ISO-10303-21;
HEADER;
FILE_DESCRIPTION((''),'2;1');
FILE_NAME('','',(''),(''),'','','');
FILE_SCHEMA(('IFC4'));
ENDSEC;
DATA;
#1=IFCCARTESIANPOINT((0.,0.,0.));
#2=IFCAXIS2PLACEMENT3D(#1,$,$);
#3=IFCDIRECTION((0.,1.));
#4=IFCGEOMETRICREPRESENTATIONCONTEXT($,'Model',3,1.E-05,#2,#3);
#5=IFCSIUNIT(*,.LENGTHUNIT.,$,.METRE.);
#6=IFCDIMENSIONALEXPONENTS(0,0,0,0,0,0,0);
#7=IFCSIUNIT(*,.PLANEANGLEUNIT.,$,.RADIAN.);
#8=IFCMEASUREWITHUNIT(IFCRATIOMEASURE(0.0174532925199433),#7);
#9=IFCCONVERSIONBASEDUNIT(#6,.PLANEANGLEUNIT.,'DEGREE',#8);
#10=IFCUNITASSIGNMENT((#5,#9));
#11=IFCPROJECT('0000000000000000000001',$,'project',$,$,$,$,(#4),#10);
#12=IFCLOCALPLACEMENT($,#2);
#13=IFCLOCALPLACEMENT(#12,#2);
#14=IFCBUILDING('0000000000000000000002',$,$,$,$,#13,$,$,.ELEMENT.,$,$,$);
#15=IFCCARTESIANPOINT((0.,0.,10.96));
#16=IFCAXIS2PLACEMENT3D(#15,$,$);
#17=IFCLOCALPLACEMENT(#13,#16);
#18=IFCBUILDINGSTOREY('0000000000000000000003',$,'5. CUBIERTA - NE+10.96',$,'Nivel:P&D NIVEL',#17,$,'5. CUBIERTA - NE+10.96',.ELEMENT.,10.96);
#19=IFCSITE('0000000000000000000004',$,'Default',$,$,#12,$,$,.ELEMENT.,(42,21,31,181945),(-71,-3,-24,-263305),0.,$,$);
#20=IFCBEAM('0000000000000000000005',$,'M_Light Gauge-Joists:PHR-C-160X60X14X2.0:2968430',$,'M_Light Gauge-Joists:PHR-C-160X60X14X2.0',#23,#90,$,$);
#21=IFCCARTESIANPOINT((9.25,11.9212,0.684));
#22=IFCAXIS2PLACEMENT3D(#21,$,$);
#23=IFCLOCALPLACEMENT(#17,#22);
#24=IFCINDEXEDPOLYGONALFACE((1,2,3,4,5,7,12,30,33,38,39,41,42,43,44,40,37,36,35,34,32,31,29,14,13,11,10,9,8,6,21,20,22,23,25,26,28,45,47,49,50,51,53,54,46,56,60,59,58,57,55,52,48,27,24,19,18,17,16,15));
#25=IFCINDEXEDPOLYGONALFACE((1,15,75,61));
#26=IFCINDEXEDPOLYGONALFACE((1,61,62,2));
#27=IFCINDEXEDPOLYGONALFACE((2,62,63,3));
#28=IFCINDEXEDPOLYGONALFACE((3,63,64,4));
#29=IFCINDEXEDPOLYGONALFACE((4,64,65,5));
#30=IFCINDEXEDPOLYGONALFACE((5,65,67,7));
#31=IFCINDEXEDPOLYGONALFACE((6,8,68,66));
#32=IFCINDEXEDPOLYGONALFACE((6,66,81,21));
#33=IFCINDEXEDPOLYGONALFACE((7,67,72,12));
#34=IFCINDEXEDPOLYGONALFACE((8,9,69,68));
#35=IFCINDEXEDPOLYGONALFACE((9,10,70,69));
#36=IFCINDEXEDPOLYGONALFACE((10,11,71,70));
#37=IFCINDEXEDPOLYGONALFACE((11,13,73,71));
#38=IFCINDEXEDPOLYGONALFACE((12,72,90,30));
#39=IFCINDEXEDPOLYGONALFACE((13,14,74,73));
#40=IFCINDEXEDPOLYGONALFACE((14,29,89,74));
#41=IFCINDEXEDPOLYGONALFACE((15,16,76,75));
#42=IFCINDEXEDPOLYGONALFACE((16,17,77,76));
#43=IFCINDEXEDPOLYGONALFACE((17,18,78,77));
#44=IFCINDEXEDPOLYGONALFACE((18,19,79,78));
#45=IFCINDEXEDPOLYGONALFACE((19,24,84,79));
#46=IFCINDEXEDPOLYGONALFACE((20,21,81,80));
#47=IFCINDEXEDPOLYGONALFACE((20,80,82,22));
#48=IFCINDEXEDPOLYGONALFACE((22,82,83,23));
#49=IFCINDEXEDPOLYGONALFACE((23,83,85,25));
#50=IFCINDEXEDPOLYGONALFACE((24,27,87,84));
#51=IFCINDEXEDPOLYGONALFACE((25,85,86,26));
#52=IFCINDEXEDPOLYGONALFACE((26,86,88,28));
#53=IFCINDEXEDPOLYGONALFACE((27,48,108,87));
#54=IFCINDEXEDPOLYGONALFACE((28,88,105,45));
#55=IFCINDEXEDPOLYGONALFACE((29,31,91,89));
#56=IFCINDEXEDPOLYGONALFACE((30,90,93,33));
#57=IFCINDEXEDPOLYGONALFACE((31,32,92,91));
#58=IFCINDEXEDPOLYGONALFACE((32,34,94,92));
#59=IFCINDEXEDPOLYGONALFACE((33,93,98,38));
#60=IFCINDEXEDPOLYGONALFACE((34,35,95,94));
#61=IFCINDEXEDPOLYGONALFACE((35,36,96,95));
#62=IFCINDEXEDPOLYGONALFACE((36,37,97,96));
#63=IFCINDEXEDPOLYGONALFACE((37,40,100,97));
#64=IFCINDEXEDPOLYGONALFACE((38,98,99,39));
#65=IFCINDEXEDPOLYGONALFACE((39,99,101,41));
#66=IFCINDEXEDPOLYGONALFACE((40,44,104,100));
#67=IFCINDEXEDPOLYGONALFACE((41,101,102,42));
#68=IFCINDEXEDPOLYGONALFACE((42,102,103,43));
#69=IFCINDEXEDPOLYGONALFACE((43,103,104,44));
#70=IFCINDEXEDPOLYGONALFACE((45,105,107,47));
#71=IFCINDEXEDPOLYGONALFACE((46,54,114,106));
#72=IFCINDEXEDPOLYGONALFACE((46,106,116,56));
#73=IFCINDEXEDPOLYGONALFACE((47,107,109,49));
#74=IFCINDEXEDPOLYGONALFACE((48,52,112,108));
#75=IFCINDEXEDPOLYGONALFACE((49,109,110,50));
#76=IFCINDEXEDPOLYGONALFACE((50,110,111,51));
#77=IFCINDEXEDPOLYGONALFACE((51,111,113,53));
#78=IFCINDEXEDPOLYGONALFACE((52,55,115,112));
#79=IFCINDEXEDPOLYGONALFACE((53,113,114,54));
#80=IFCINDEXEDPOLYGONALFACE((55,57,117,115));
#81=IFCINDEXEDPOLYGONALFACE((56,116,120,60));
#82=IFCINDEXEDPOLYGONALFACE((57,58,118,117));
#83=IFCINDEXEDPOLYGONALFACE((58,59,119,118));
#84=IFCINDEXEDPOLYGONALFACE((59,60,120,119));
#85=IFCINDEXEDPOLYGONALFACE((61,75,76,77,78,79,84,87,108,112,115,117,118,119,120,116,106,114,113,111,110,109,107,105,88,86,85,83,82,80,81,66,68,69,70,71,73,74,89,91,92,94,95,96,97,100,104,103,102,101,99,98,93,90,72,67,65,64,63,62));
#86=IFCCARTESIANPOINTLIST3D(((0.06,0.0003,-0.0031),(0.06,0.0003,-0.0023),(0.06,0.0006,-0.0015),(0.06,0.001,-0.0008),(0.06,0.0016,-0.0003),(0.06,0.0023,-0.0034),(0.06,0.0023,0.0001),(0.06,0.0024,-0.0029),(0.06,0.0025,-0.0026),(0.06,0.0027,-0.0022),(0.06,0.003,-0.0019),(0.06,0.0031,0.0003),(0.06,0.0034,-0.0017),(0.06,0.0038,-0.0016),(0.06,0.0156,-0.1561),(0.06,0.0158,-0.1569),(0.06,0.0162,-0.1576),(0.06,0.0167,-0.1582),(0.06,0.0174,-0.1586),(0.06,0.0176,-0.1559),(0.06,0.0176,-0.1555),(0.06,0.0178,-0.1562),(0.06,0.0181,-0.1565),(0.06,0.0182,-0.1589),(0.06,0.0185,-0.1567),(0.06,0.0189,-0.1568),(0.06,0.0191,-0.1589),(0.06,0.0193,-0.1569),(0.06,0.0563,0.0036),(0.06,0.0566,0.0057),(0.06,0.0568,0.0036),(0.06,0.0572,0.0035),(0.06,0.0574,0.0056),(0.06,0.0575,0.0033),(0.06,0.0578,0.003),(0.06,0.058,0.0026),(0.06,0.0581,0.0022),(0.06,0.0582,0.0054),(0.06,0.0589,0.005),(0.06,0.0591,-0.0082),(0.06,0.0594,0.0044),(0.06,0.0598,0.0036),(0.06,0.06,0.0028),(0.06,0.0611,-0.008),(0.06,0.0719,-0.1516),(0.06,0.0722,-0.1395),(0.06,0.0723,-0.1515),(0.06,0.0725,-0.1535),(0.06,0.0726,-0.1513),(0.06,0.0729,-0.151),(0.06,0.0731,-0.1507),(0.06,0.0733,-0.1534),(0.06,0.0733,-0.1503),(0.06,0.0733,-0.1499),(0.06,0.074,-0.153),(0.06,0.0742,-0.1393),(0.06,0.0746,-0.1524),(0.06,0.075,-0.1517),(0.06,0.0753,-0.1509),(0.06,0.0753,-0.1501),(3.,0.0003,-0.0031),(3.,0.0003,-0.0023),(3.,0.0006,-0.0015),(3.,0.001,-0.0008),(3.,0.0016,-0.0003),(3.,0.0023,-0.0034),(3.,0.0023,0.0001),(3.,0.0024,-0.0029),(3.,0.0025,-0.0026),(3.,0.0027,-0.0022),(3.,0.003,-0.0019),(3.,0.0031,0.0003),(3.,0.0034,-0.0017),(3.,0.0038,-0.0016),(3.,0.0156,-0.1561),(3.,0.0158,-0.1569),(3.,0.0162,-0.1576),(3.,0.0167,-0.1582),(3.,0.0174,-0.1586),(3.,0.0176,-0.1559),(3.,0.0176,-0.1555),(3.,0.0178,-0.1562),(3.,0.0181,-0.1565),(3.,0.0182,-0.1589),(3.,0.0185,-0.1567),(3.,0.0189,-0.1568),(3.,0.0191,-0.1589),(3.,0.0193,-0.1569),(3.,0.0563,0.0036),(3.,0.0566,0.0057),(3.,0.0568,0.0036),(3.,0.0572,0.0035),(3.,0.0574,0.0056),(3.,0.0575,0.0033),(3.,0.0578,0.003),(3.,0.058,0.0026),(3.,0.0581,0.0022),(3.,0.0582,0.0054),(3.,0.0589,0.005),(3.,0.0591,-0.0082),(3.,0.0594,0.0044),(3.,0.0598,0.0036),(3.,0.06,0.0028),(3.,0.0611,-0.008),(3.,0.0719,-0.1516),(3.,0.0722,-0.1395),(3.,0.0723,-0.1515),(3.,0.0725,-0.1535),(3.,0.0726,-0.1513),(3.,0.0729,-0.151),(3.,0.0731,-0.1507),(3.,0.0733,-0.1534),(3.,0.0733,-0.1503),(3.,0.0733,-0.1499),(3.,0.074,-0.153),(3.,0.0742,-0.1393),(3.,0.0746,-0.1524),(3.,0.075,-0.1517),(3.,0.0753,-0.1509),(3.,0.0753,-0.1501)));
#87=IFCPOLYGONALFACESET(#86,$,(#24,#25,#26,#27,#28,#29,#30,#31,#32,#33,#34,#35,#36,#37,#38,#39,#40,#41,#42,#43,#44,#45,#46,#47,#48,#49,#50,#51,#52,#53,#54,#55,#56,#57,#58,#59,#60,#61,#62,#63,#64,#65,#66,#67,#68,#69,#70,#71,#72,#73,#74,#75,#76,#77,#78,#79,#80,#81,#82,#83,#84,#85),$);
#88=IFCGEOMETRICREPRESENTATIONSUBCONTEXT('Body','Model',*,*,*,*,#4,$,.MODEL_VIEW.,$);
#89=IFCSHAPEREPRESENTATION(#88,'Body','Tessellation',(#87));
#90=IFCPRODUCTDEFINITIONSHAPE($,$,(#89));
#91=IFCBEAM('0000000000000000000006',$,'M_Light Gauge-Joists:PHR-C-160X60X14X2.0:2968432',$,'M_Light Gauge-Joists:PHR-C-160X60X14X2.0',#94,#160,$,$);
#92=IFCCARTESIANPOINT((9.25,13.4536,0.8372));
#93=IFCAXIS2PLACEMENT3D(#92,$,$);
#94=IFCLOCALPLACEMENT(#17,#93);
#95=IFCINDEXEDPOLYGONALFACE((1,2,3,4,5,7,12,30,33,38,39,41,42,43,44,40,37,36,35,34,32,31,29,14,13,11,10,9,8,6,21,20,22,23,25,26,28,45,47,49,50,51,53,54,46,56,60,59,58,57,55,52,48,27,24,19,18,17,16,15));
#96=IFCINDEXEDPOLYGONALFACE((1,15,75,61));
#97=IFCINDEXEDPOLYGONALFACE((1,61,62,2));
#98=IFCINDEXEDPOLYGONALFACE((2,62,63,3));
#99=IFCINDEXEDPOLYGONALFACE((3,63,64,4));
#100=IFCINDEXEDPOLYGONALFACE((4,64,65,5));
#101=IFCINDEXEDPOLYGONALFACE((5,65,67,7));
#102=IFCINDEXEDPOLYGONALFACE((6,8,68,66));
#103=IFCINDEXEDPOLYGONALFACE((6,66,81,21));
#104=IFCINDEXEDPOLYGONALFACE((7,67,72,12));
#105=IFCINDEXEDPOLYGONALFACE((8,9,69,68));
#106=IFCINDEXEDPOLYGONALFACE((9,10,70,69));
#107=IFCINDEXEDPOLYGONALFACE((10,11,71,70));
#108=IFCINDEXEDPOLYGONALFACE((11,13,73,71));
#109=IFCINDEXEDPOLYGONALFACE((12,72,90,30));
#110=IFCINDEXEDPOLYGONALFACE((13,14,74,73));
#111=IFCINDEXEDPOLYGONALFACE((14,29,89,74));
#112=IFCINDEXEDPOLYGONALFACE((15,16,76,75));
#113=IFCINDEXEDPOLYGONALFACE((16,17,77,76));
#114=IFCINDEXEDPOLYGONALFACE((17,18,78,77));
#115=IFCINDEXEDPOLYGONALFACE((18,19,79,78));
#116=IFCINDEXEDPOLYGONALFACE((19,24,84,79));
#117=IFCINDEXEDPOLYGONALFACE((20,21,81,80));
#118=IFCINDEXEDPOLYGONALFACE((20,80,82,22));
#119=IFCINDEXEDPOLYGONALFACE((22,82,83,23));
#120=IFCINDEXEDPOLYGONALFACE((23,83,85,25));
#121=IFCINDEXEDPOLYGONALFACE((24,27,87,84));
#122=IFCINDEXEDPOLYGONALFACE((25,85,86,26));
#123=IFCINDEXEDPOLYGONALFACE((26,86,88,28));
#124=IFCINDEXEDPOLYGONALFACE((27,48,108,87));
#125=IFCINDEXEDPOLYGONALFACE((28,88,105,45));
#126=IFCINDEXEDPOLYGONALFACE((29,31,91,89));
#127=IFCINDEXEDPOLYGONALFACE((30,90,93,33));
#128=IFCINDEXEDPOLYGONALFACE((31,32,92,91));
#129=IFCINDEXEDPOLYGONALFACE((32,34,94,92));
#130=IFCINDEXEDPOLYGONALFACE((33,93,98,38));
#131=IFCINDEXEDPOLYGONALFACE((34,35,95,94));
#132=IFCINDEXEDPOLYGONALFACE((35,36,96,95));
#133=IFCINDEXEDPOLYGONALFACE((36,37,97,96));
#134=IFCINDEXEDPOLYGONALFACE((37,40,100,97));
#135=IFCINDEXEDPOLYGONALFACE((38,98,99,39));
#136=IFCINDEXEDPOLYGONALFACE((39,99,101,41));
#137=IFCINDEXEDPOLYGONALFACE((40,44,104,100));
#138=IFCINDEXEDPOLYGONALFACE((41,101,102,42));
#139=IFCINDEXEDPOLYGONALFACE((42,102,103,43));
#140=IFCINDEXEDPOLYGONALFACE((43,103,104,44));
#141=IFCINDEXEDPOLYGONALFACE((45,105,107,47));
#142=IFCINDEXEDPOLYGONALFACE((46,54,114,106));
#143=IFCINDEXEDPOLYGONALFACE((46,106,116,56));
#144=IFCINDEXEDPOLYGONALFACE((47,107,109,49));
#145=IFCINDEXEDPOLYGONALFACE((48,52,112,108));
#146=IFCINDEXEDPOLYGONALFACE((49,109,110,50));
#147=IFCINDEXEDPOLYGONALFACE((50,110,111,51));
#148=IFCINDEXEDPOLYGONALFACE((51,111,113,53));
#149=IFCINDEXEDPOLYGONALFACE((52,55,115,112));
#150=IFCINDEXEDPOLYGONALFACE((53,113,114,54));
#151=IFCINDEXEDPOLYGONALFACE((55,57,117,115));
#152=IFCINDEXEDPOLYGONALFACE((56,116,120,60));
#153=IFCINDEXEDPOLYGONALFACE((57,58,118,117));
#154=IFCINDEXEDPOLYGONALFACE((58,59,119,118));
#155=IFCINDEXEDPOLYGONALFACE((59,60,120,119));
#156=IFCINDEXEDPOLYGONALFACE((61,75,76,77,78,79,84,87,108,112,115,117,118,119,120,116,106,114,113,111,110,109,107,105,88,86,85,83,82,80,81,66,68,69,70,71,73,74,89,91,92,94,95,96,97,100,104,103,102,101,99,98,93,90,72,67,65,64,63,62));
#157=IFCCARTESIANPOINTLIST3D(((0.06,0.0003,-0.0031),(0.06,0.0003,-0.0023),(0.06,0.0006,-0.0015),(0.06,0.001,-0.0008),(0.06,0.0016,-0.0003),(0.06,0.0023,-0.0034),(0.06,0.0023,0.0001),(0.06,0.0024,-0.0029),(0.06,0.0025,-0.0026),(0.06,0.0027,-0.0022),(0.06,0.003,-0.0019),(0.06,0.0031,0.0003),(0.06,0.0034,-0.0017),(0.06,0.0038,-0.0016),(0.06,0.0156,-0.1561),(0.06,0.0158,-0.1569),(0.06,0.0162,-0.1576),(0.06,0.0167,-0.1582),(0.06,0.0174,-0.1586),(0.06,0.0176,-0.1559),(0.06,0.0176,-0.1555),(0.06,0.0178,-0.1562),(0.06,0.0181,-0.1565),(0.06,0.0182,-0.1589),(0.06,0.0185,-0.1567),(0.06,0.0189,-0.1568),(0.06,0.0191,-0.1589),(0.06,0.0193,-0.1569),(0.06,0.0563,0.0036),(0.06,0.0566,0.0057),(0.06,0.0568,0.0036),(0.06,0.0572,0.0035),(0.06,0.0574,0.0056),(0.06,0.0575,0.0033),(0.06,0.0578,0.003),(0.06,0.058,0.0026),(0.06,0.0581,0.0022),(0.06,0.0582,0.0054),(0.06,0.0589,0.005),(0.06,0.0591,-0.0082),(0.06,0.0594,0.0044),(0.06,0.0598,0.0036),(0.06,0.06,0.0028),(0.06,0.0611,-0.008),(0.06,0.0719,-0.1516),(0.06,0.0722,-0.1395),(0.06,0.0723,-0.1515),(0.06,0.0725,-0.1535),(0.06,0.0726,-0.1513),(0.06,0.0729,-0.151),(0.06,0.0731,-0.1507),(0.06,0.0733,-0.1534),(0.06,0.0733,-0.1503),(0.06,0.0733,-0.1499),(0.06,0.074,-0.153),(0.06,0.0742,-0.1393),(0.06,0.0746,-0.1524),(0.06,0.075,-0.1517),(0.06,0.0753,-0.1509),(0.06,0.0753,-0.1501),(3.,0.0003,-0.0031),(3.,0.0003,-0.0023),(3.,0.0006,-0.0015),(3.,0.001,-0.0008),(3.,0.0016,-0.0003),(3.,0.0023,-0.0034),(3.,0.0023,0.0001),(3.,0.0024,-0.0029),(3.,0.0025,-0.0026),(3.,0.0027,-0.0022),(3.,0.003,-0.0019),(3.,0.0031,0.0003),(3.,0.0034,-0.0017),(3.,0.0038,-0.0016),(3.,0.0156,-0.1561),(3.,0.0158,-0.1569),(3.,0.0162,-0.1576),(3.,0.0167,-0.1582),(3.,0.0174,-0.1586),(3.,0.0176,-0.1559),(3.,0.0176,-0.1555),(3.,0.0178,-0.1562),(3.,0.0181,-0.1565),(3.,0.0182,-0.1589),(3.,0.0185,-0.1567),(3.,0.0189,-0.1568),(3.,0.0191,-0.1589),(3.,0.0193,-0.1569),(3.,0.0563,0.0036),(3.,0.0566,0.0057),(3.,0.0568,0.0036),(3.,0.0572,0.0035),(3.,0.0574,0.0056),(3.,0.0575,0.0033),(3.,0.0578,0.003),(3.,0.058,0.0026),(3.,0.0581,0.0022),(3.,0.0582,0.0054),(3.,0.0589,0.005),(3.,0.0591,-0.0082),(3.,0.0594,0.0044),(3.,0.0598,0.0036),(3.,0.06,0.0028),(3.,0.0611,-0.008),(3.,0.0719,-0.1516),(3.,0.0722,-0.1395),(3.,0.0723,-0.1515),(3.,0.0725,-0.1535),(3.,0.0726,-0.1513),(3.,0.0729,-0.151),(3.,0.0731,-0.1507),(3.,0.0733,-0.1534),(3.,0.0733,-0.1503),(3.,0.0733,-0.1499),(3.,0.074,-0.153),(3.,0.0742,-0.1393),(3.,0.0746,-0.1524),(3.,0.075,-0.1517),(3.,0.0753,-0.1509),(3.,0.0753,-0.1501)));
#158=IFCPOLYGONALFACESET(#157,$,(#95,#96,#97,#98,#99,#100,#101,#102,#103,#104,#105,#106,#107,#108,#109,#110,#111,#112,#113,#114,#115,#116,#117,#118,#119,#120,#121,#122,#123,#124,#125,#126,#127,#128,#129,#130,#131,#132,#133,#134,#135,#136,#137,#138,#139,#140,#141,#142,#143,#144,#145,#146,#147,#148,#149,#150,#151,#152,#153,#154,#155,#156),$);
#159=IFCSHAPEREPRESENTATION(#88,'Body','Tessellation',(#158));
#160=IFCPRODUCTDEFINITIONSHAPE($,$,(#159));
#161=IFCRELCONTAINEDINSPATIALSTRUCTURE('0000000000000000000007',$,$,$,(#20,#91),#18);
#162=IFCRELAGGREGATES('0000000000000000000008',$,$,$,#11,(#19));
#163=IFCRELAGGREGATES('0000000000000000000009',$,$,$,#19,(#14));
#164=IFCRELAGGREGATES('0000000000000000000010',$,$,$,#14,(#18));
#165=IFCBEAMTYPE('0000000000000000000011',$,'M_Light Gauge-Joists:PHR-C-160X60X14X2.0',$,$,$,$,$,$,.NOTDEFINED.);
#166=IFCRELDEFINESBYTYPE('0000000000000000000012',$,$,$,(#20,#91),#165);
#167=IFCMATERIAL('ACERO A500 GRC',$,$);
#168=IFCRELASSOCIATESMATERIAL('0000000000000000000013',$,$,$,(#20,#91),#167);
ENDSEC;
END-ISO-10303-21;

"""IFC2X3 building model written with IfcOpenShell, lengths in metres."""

from ifc_helpers import new_model, entity, si_unit, converted_unit, direction, frame, frame_2d, origin, place, context, subcontext, project, spatial, polyline, circle_curve, parameter, trimmed, segment, composite_curve, outline, extrude, material, type_object, element, save


model = new_model("IFC2X3")

# Units and contexts
model_context = context("Model", 3, precision=1e-05, world=origin(), true_north=direction((0.0, 1.0)))
body_context = subcontext(model_context, "Body", "Model", "MODEL_VIEW")
ifc_project = project(units=[si_unit("LENGTHUNIT", "METRE"), converted_unit("PLANEANGLEUNIT", "DEGREE", entity("IfcRatioMeasure", 0.0174532925199433), si_unit("PLANEANGLEUNIT", "RADIAN"), dimensions=[0, 0, 0, 0, 0, 0, 0])], contexts=[model_context])

# Site, building, storey
site_placement = place(None, origin())
site = spatial("IfcSite", under=ifc_project, at=site_placement, Name="Default", CompositionType="ELEMENT", RefLatitude=(42, 21, 31, 181945), RefLongitude=(-71, -3, -24, -263305), RefElevation=0.0)
building_placement = place(site_placement, origin())
building = spatial("IfcBuilding", under=site, at=building_placement, CompositionType="ELEMENT")
storey_placement = place(building_placement, frame((0.0, 0.0, 10.96)))
storey = spatial("IfcBuildingStorey", under=building, at=storey_placement, Name="5. CUBIERTA - NE+10.96", ObjectType="Nivel:P&D NIVEL", LongName="5. CUBIERTA - NE+10.96", CompositionType="ELEMENT", Elevation=10.96)

# Beams
ifc_material_1 = material(Name="ACERO A500 GRC")
beam_type_1 = type_object("IfcBeamType", Name="M_Light Gauge-Joists:PHR-C-160X60X14X2.0", PredefinedType="NOTDEFINED")
beam_1_placement = place(storey_placement, frame((9.25, 11.9212, 0.684)))
element("IfcBeam", 1, at=beam_1_placement, inside=storey, type_object=beam_type_1, material=ifc_material_1, Name="M_Light Gauge-Joists:PHR-C-160X60X14X2.0:2968430", ObjectType="M_Light Gauge-Joists:PHR-C-160X60X14X2.0", context=body_context, shape_type="SweptSolid", body=[
    extrude(outline(composite_curve([segment(trimmed(circle_curve(frame_2d((-0.0764, -0.0322), x_axis=(-1.0, 0.0)), 0.0016), [parameter(0.0)], [parameter(90.0)], True, "PARAMETER"), False, "CONTINUOUS"), segment(polyline([(-0.078, -0.0322), (-0.078, 0.0206)]), True, "CONTINUOUS"), segment(trimmed(circle_curve(frame_2d((-0.0764, 0.0206), x_axis=(0.0, 1.0)), 0.0016), [parameter(0.0)], [parameter(90.0)], True, "PARAMETER"), False, "CONTINUOUS"), segment(polyline([(-0.0764, 0.0222), (-0.066, 0.0222)]), True, "CONTINUOUS"), segment(polyline([(-0.066, 0.0222), (-0.066, 0.0242)]), True, "CONTINUOUS"), segment(polyline([(-0.066, 0.0242), (-0.0768, 0.0242)]), True, "CONTINUOUS"), segment(trimmed(circle_curve(frame_2d((-0.0768, 0.021), x_axis=(-1.0, 0.0)), 0.0032), [parameter(270.0)], [parameter(0.0)], True, "PARAMETER"), True, "CONTINUOUS"), segment(polyline([(-0.08, 0.021), (-0.08, -0.0326)]), True, "CONTINUOUS"), segment(trimmed(circle_curve(frame_2d((-0.0768, -0.0326), x_axis=(0.0, -1.0)), 0.0032), [parameter(270.0)], [parameter(0.0)], True, "PARAMETER"), True, "CONTINUOUS"), segment(polyline([(-0.0768, -0.0358), (0.0768, -0.0358)]), True, "CONTINUOUS"), segment(trimmed(circle_curve(frame_2d((0.0768, -0.0326), x_axis=(1.0, 0.0)), 0.0032), [parameter(270.0)], [parameter(0.0)], True, "PARAMETER"), True, "CONTINUOUS"), segment(polyline([(0.08, -0.0326), (0.08, 0.021)]), True, "CONTINUOUS"), segment(trimmed(circle_curve(frame_2d((0.0768, 0.021), x_axis=(0.0, 1.0)), 0.0032), [parameter(270.0)], [parameter(0.0)], True, "PARAMETER"), True, "CONTINUOUS"), segment(polyline([(0.0768, 0.0242), (0.066, 0.0242)]), True, "CONTINUOUS"), segment(polyline([(0.066, 0.0242), (0.066, 0.0222)]), True, "CONTINUOUS"), segment(polyline([(0.066, 0.0222), (0.0764, 0.0222)]), True, "CONTINUOUS"), segment(trimmed(circle_curve(frame_2d((0.0764, 0.0206), x_axis=(1.0, 0.0)), 0.0016), [parameter(0.0)], [parameter(90.0)], True, "PARAMETER"), False, "CONTINUOUS"), segment(polyline([(0.078, 0.0206), (0.078, -0.0322)]), True, "CONTINUOUS"), segment(trimmed(circle_curve(frame_2d((0.0764, -0.0322), x_axis=(0.0, -1.0)), 0.0016), [parameter(0.0)], [parameter(90.0)], True, "PARAMETER"), False, "CONTINUOUS"), segment(polyline([(0.0764, -0.0338), (-0.0764, -0.0338)]), True, "CONTINUOUS")], self_intersect=False)), frame((0.06, 0.0436, -0.076), z_axis=(-1.0, 0.0, 0.0), x_axis=(0.0, -0.099504, 0.995037)), (0.0, 0.0, -1.0), 2.94),
])
beam_2_placement = place(storey_placement, frame((9.25, 13.4536, 0.8372)))
element("IfcBeam", 2, at=beam_2_placement, inside=storey, type_object=beam_type_1, material=ifc_material_1, Name="M_Light Gauge-Joists:PHR-C-160X60X14X2.0:2968432", ObjectType="M_Light Gauge-Joists:PHR-C-160X60X14X2.0", context=body_context, shape_type="SweptSolid", body=[
    extrude(outline(composite_curve([segment(trimmed(circle_curve(frame_2d((-0.0764, -0.0322), x_axis=(-1.0, 0.0)), 0.0016), [parameter(0.0)], [parameter(90.0)], True, "PARAMETER"), False, "CONTINUOUS"), segment(polyline([(-0.078, -0.0322), (-0.078, 0.0206)]), True, "CONTINUOUS"), segment(trimmed(circle_curve(frame_2d((-0.0764, 0.0206), x_axis=(0.0, 1.0)), 0.0016), [parameter(0.0)], [parameter(90.0)], True, "PARAMETER"), False, "CONTINUOUS"), segment(polyline([(-0.0764, 0.0222), (-0.066, 0.0222)]), True, "CONTINUOUS"), segment(polyline([(-0.066, 0.0222), (-0.066, 0.0242)]), True, "CONTINUOUS"), segment(polyline([(-0.066, 0.0242), (-0.0768, 0.0242)]), True, "CONTINUOUS"), segment(trimmed(circle_curve(frame_2d((-0.0768, 0.021), x_axis=(-1.0, 0.0)), 0.0032), [parameter(270.0)], [parameter(0.0)], True, "PARAMETER"), True, "CONTINUOUS"), segment(polyline([(-0.08, 0.021), (-0.08, -0.0326)]), True, "CONTINUOUS"), segment(trimmed(circle_curve(frame_2d((-0.0768, -0.0326), x_axis=(0.0, -1.0)), 0.0032), [parameter(270.0)], [parameter(0.0)], True, "PARAMETER"), True, "CONTINUOUS"), segment(polyline([(-0.0768, -0.0358), (0.0768, -0.0358)]), True, "CONTINUOUS"), segment(trimmed(circle_curve(frame_2d((0.0768, -0.0326), x_axis=(1.0, 0.0)), 0.0032), [parameter(270.0)], [parameter(0.0)], True, "PARAMETER"), True, "CONTINUOUS"), segment(polyline([(0.08, -0.0326), (0.08, 0.021)]), True, "CONTINUOUS"), segment(trimmed(circle_curve(frame_2d((0.0768, 0.021), x_axis=(0.0, 1.0)), 0.0032), [parameter(270.0)], [parameter(0.0)], True, "PARAMETER"), True, "CONTINUOUS"), segment(polyline([(0.0768, 0.0242), (0.066, 0.0242)]), True, "CONTINUOUS"), segment(polyline([(0.066, 0.0242), (0.066, 0.0222)]), True, "CONTINUOUS"), segment(polyline([(0.066, 0.0222), (0.0764, 0.0222)]), True, "CONTINUOUS"), segment(trimmed(circle_curve(frame_2d((0.0764, 0.0206), x_axis=(1.0, 0.0)), 0.0016), [parameter(0.0)], [parameter(90.0)], True, "PARAMETER"), False, "CONTINUOUS"), segment(polyline([(0.078, 0.0206), (0.078, -0.0322)]), True, "CONTINUOUS"), segment(trimmed(circle_curve(frame_2d((0.0764, -0.0322), x_axis=(0.0, -1.0)), 0.0016), [parameter(0.0)], [parameter(90.0)], True, "PARAMETER"), False, "CONTINUOUS"), segment(polyline([(0.0764, -0.0338), (-0.0764, -0.0338)]), True, "CONTINUOUS")], self_intersect=False)), frame((0.06, 0.0436, -0.076), z_axis=(-1.0, 0.0, 0.0), x_axis=(0.0, -0.099504, 0.995037)), (0.0, 0.0, -1.0), 2.94),
])

save(model, "model.ifc")
